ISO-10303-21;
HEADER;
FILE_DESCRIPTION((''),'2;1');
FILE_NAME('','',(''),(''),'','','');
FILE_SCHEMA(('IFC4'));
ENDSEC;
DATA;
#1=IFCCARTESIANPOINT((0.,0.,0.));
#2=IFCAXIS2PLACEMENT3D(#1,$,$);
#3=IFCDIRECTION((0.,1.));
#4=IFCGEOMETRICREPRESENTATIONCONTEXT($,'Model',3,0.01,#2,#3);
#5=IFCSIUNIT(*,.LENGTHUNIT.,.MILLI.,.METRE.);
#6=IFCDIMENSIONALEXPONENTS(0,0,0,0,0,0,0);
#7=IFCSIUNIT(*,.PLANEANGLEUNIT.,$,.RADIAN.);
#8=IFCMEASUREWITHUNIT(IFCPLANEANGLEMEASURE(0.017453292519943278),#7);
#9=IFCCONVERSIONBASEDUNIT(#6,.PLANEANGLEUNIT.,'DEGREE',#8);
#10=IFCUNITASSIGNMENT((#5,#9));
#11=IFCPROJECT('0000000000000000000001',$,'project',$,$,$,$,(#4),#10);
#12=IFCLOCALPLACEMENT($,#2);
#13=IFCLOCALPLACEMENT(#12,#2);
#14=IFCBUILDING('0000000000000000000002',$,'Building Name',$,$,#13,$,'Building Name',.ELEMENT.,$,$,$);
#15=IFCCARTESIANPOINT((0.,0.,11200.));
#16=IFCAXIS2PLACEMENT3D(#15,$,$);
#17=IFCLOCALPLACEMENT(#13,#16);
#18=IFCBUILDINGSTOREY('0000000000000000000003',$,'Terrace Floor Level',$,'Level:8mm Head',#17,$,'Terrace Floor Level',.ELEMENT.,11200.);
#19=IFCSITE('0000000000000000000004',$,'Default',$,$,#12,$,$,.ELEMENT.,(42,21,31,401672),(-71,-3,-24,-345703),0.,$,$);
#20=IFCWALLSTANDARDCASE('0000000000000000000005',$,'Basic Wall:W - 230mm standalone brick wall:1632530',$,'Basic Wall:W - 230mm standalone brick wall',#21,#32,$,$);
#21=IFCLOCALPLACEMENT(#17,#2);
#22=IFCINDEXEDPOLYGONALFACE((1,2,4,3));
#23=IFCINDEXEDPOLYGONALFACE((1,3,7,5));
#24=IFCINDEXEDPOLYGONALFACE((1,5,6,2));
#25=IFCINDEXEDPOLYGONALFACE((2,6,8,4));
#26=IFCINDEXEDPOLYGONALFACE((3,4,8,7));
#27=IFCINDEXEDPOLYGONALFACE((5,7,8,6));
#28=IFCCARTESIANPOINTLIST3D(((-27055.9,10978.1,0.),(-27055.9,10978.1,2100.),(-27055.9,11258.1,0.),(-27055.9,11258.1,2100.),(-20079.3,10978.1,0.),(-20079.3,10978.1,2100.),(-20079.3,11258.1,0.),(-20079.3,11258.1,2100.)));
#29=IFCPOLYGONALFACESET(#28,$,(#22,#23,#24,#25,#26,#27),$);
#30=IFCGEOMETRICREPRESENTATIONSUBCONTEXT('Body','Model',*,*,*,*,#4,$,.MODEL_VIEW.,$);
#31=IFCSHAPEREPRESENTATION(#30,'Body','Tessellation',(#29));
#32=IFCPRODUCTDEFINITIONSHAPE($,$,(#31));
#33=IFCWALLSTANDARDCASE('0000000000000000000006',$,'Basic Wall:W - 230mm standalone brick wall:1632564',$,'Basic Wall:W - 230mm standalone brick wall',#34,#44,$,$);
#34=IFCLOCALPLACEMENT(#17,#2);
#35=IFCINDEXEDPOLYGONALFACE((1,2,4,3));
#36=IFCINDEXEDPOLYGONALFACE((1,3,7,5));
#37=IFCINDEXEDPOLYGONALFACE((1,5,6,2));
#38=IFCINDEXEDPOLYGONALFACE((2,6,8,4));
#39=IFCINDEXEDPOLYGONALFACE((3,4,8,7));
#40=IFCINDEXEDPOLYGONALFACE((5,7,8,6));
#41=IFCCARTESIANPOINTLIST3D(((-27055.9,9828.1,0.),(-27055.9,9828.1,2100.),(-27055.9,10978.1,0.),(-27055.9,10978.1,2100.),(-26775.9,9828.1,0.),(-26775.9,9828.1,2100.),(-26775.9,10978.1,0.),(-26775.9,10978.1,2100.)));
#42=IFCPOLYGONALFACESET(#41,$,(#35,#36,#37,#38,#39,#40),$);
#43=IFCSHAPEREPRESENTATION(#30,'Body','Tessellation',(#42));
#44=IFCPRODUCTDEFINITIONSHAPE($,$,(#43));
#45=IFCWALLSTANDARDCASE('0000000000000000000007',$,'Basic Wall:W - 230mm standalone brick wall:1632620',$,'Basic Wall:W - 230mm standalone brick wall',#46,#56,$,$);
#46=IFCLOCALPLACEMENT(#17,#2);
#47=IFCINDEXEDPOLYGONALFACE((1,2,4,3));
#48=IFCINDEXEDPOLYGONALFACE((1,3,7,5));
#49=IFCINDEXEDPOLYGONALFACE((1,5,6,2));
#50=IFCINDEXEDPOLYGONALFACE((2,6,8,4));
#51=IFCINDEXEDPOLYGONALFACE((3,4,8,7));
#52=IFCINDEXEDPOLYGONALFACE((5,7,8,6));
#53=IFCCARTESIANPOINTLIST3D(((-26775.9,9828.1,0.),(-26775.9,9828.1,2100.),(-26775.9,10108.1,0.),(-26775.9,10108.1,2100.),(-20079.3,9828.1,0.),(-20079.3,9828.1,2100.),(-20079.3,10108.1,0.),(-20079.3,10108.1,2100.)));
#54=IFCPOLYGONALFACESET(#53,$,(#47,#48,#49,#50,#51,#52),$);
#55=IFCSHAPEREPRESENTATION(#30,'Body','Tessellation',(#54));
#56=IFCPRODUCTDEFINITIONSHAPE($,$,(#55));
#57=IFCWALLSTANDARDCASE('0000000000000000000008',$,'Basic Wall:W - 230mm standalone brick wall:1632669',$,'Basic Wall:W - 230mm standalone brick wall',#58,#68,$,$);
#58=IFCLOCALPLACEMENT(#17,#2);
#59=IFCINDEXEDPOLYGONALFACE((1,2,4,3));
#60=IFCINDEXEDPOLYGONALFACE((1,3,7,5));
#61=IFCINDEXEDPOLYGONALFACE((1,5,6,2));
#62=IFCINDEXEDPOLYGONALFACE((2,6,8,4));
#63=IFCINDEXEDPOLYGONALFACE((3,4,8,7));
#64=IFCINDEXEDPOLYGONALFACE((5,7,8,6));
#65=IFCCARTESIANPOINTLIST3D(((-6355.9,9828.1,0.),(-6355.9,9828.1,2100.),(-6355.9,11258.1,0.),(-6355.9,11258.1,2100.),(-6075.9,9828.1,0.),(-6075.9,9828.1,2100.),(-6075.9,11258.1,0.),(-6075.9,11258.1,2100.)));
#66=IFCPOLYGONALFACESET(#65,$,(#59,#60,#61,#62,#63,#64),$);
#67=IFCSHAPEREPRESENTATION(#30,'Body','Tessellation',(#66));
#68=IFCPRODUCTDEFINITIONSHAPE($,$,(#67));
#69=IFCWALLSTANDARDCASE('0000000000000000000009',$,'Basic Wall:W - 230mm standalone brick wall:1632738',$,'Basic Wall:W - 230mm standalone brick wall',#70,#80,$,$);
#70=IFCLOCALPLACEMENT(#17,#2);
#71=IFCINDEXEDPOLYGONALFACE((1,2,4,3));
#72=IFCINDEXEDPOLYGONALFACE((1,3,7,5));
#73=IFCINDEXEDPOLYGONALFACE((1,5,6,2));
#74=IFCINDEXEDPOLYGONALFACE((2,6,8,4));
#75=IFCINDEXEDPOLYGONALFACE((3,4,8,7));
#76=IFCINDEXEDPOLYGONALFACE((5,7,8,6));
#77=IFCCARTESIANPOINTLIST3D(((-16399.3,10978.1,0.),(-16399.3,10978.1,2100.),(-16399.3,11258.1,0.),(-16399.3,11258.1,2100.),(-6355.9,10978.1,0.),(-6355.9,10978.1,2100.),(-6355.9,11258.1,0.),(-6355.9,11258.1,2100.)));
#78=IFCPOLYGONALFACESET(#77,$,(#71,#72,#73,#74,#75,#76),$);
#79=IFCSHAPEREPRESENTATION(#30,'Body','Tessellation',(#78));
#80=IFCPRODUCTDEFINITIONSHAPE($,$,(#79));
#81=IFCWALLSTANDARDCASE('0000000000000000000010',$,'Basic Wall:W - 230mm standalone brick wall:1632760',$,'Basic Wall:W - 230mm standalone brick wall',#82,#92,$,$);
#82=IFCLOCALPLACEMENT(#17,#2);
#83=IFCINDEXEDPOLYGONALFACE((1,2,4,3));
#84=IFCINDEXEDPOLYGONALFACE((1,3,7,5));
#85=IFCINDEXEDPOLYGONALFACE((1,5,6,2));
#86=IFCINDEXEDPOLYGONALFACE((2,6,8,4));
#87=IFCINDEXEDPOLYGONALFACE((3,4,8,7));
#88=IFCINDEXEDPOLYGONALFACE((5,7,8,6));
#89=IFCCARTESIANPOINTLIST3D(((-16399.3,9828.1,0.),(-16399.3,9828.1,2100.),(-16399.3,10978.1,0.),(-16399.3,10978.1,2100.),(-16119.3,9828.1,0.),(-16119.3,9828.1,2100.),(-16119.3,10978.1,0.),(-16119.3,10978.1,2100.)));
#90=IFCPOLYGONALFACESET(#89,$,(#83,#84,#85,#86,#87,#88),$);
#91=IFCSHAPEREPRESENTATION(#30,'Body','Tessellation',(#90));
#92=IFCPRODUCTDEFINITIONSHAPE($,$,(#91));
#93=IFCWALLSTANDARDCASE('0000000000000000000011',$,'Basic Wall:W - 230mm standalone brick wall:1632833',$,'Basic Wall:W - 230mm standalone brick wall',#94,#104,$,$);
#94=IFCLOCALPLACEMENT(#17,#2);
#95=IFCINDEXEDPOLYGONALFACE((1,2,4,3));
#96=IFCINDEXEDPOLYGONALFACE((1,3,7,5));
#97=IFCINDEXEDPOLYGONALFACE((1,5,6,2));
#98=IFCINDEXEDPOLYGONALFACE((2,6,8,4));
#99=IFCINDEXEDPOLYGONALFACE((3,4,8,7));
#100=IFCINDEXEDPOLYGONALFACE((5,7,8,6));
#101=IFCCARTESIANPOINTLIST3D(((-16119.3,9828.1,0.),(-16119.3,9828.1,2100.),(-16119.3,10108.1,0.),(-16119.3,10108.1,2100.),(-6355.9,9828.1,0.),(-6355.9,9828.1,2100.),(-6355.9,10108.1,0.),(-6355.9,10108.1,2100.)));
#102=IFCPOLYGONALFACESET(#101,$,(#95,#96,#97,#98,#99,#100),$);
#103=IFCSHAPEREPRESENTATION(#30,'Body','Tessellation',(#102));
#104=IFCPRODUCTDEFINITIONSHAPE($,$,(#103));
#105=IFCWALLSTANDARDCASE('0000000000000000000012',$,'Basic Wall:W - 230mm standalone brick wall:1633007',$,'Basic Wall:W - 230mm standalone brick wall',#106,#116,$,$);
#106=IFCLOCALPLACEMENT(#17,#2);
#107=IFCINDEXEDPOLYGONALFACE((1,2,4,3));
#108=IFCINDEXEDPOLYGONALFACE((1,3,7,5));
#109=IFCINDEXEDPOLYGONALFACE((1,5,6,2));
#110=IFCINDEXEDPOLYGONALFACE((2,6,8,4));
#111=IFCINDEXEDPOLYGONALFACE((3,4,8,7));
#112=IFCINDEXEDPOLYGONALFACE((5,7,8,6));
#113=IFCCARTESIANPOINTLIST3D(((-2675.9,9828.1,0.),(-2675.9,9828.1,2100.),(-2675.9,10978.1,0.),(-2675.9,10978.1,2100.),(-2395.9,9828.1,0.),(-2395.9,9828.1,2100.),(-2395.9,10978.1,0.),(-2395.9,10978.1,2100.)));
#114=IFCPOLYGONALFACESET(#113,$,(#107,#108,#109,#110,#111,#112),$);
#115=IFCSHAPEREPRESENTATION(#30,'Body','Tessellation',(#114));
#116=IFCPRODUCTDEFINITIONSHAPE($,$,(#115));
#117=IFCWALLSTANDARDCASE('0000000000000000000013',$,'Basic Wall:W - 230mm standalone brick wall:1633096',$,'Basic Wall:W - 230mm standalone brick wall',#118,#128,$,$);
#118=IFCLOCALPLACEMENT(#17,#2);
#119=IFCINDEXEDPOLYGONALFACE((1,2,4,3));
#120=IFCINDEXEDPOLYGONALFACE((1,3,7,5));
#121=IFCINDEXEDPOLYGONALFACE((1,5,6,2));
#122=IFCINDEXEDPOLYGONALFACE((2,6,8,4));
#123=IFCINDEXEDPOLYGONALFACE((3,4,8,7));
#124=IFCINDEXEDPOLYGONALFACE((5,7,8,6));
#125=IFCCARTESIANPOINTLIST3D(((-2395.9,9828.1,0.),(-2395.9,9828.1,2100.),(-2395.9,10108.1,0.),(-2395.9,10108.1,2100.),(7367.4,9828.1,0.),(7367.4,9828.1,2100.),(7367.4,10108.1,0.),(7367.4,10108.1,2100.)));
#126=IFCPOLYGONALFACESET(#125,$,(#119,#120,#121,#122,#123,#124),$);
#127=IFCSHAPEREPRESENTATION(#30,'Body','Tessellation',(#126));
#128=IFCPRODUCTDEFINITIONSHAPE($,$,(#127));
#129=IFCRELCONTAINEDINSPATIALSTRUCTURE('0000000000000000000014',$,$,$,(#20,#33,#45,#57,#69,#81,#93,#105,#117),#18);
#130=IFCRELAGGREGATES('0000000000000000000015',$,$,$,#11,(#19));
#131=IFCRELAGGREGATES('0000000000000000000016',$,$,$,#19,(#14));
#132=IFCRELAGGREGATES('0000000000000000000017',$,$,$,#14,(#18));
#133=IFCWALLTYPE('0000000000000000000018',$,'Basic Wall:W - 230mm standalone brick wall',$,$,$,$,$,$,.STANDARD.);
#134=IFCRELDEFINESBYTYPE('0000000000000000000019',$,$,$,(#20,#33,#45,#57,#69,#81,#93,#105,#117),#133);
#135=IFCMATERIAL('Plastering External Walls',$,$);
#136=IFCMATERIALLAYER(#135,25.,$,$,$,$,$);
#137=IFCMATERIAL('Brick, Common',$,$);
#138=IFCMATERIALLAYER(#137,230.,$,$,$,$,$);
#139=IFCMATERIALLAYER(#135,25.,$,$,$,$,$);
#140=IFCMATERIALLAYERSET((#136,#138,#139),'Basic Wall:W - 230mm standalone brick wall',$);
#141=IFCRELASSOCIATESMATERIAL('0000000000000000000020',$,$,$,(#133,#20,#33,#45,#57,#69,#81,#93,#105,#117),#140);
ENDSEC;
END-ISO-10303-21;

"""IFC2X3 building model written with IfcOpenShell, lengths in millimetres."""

from ifc_helpers import new_model, entity, si_unit, converted_unit, direction, frame, frame_2d, origin, place, context, subcontext, project, spatial, rectangle, extrude, material, layer, layer_set, layer_usage, type_object, element, save


model = new_model("IFC2X3")

# Units and contexts
model_context = context("Model", 3, precision=0.01, world=origin(), true_north=direction((0.0, 1.0)))
body_context = subcontext(model_context, "Body", "Model", "MODEL_VIEW")
ifc_project = project(units=[si_unit("LENGTHUNIT", "METRE", prefix="MILLI"), converted_unit("PLANEANGLEUNIT", "DEGREE", entity("IfcPlaneAngleMeasure", 0.017453292519943278), si_unit("PLANEANGLEUNIT", "RADIAN"), dimensions=[0, 0, 0, 0, 0, 0, 0])], contexts=[model_context])

# Site, building, storey
site_placement = place(None, origin())
site = spatial("IfcSite", under=ifc_project, at=site_placement, Name="Default", CompositionType="ELEMENT", RefLatitude=(42, 21, 31, 401672), RefLongitude=(-71, -3, -24, -345703), RefElevation=0.0)
building_placement = place(site_placement, origin())
building = spatial("IfcBuilding", under=site, at=building_placement, Name="Building Name", LongName="Building Name", CompositionType="ELEMENT")
storey_placement = place(building_placement, frame((0.0, 0.0, 11200.0)))
storey = spatial("IfcBuildingStorey", under=building, at=storey_placement, Name="Terrace Floor Level", ObjectType="Level:8mm Head", LongName="Terrace Floor Level", CompositionType="ELEMENT", Elevation=11200.0)

# Walls
ifc_material_1 = material(Name="Plastering External Walls")
ifc_layer_1 = layer(ifc_material_1, 25.0)
ifc_material_2 = material(Name="Brick, Common")
ifc_layer_2 = layer(ifc_material_2, 230.0)
ifc_layer_3 = layer(ifc_material_1, 25.0)
ifc_layer_set = layer_set([ifc_layer_1, ifc_layer_2, ifc_layer_3], Name="Basic Wall:W - 230mm standalone brick wall")
wall_type = type_object("IfcWallType", Name="Basic Wall:W - 230mm standalone brick wall", PredefinedType="STANDARD", material=ifc_layer_set)
ifc_layer_usage_1 = layer_usage(ifc_layer_set, "AXIS2", "NEGATIVE", 140.0)
wall_1_placement = place(storey_placement, frame((-20079.3, 11118.1, 0.0), z_axis=(0.0, 0.0, 1.0), x_axis=(-1.0, 0.0, 0.0)))
element("IfcWallStandardCase", 1, at=wall_1_placement, inside=storey, type_object=wall_type, material=ifc_layer_usage_1, Name="Basic Wall:W - 230mm standalone brick wall:1632530", ObjectType="Basic Wall:W - 230mm standalone brick wall", context=body_context, shape_type="SweptSolid", body=[
    extrude(rectangle(XDim=6976.7, YDim=280.0, at=frame_2d((3488.3, 0.0), x_axis=(-1.0, 0.0))), origin(), (0.0, 0.0, 1.0), 2100.0),
])
ifc_layer_usage_2 = layer_usage(ifc_layer_set, "AXIS2", "NEGATIVE", 140.0)
wall_2_placement = place(storey_placement, frame((-26915.9, 10978.1, 0.0), z_axis=(0.0, 0.0, 1.0), x_axis=(0.0, -1.0, 0.0)))
element("IfcWallStandardCase", 2, at=wall_2_placement, inside=storey, type_object=wall_type, material=ifc_layer_usage_2, Name="Basic Wall:W - 230mm standalone brick wall:1632564", ObjectType="Basic Wall:W - 230mm standalone brick wall", context=body_context, shape_type="SweptSolid", body=[
    extrude(rectangle(XDim=1150.0, YDim=280.0, at=frame_2d((575.0, 0.0), x_axis=(-1.0, 0.0))), origin(), (0.0, 0.0, 1.0), 2100.0),
])
ifc_layer_usage_3 = layer_usage(ifc_layer_set, "AXIS2", "NEGATIVE", 140.0)
wall_3_placement = place(storey_placement, frame((-26775.9, 9968.1, 0.0)))
element("IfcWallStandardCase", 3, at=wall_3_placement, inside=storey, type_object=wall_type, material=ifc_layer_usage_3, Name="Basic Wall:W - 230mm standalone brick wall:1632620", ObjectType="Basic Wall:W - 230mm standalone brick wall", context=body_context, shape_type="SweptSolid", body=[
    extrude(rectangle(XDim=6696.7, YDim=280.0, at=frame_2d((3348.3, 0.0), x_axis=(-1.0, 0.0))), origin(), (0.0, 0.0, 1.0), 2100.0),
])
ifc_layer_usage_4 = layer_usage(ifc_layer_set, "AXIS2", "NEGATIVE", 140.0)
wall_4_placement = place(storey_placement, frame((-6215.9, 9828.1, 0.0), z_axis=(0.0, 0.0, 1.0), x_axis=(0.0, 1.0, 0.0)))
element("IfcWallStandardCase", 4, at=wall_4_placement, inside=storey, type_object=wall_type, material=ifc_layer_usage_4, Name="Basic Wall:W - 230mm standalone brick wall:1632669", ObjectType="Basic Wall:W - 230mm standalone brick wall", context=body_context, shape_type="SweptSolid", body=[
    extrude(rectangle(XDim=1430.0, YDim=280.0, at=frame_2d((715.0, 0.0), x_axis=(-1.0, 0.0))), origin(), (0.0, 0.0, 1.0), 2100.0),
])
ifc_layer_usage_5 = layer_usage(ifc_layer_set, "AXIS2", "NEGATIVE", 140.0)
wall_5_placement = place(storey_placement, frame((-6355.9, 11118.1, 0.0), z_axis=(0.0, 0.0, 1.0), x_axis=(-1.0, 0.0, 0.0)))
element("IfcWallStandardCase", 5, at=wall_5_placement, inside=storey, type_object=wall_type, material=ifc_layer_usage_5, Name="Basic Wall:W - 230mm standalone brick wall:1632738", ObjectType="Basic Wall:W - 230mm standalone brick wall", context=body_context, shape_type="SweptSolid", body=[
    extrude(rectangle(XDim=10043.3, YDim=280.0, at=frame_2d((5021.7, 0.0), x_axis=(-1.0, 0.0))), origin(), (0.0, 0.0, 1.0), 2100.0),
])
ifc_layer_usage_6 = layer_usage(ifc_layer_set, "AXIS2", "NEGATIVE", 140.0)
wall_6_placement = place(storey_placement, frame((-16259.3, 10978.1, 0.0), z_axis=(0.0, 0.0, 1.0), x_axis=(0.0, -1.0, 0.0)))
element("IfcWallStandardCase", 6, at=wall_6_placement, inside=storey, type_object=wall_type, material=ifc_layer_usage_6, Name="Basic Wall:W - 230mm standalone brick wall:1632760", ObjectType="Basic Wall:W - 230mm standalone brick wall", context=body_context, shape_type="SweptSolid", body=[
    extrude(rectangle(XDim=1150.0, YDim=280.0, at=frame_2d((575.0, 0.0), x_axis=(-1.0, 0.0))), origin(), (0.0, 0.0, 1.0), 2100.0),
])
ifc_layer_usage_7 = layer_usage(ifc_layer_set, "AXIS2", "NEGATIVE", 140.0)
wall_7_placement = place(storey_placement, frame((-16119.3, 9968.1, 0.0)))
element("IfcWallStandardCase", 7, at=wall_7_placement, inside=storey, type_object=wall_type, material=ifc_layer_usage_7, Name="Basic Wall:W - 230mm standalone brick wall:1632833", ObjectType="Basic Wall:W - 230mm standalone brick wall", context=body_context, shape_type="SweptSolid", body=[
    extrude(rectangle(XDim=9763.3, YDim=280.0, at=frame_2d((4881.7, 0.0), x_axis=(-1.0, 0.0))), origin(), (0.0, 0.0, 1.0), 2100.0),
])
ifc_layer_usage_8 = layer_usage(ifc_layer_set, "AXIS2", "NEGATIVE", 140.0)
wall_8_placement = place(storey_placement, frame((-2535.9, 10978.1, 0.0), z_axis=(0.0, 0.0, 1.0), x_axis=(0.0, -1.0, 0.0)))
element("IfcWallStandardCase", 8, at=wall_8_placement, inside=storey, type_object=wall_type, material=ifc_layer_usage_8, Name="Basic Wall:W - 230mm standalone brick wall:1633007", ObjectType="Basic Wall:W - 230mm standalone brick wall", context=body_context, shape_type="SweptSolid", body=[
    extrude(rectangle(XDim=1150.0, YDim=280.0, at=frame_2d((575.0, 0.0), x_axis=(-1.0, 0.0))), origin(), (0.0, 0.0, 1.0), 2100.0),
])
ifc_layer_usage_9 = layer_usage(ifc_layer_set, "AXIS2", "NEGATIVE", 140.0)
wall_9_placement = place(storey_placement, frame((-2395.9, 9968.1, 0.0)))
element("IfcWallStandardCase", 9, at=wall_9_placement, inside=storey, type_object=wall_type, material=ifc_layer_usage_9, Name="Basic Wall:W - 230mm standalone brick wall:1633096", ObjectType="Basic Wall:W - 230mm standalone brick wall", context=body_context, shape_type="SweptSolid", body=[
    extrude(rectangle(XDim=9763.3, YDim=280.0, at=frame_2d((4881.7, 0.0), x_axis=(-1.0, 0.0))), origin(), (0.0, 0.0, 1.0), 2100.0),
])

save(model, "model.ifc")
